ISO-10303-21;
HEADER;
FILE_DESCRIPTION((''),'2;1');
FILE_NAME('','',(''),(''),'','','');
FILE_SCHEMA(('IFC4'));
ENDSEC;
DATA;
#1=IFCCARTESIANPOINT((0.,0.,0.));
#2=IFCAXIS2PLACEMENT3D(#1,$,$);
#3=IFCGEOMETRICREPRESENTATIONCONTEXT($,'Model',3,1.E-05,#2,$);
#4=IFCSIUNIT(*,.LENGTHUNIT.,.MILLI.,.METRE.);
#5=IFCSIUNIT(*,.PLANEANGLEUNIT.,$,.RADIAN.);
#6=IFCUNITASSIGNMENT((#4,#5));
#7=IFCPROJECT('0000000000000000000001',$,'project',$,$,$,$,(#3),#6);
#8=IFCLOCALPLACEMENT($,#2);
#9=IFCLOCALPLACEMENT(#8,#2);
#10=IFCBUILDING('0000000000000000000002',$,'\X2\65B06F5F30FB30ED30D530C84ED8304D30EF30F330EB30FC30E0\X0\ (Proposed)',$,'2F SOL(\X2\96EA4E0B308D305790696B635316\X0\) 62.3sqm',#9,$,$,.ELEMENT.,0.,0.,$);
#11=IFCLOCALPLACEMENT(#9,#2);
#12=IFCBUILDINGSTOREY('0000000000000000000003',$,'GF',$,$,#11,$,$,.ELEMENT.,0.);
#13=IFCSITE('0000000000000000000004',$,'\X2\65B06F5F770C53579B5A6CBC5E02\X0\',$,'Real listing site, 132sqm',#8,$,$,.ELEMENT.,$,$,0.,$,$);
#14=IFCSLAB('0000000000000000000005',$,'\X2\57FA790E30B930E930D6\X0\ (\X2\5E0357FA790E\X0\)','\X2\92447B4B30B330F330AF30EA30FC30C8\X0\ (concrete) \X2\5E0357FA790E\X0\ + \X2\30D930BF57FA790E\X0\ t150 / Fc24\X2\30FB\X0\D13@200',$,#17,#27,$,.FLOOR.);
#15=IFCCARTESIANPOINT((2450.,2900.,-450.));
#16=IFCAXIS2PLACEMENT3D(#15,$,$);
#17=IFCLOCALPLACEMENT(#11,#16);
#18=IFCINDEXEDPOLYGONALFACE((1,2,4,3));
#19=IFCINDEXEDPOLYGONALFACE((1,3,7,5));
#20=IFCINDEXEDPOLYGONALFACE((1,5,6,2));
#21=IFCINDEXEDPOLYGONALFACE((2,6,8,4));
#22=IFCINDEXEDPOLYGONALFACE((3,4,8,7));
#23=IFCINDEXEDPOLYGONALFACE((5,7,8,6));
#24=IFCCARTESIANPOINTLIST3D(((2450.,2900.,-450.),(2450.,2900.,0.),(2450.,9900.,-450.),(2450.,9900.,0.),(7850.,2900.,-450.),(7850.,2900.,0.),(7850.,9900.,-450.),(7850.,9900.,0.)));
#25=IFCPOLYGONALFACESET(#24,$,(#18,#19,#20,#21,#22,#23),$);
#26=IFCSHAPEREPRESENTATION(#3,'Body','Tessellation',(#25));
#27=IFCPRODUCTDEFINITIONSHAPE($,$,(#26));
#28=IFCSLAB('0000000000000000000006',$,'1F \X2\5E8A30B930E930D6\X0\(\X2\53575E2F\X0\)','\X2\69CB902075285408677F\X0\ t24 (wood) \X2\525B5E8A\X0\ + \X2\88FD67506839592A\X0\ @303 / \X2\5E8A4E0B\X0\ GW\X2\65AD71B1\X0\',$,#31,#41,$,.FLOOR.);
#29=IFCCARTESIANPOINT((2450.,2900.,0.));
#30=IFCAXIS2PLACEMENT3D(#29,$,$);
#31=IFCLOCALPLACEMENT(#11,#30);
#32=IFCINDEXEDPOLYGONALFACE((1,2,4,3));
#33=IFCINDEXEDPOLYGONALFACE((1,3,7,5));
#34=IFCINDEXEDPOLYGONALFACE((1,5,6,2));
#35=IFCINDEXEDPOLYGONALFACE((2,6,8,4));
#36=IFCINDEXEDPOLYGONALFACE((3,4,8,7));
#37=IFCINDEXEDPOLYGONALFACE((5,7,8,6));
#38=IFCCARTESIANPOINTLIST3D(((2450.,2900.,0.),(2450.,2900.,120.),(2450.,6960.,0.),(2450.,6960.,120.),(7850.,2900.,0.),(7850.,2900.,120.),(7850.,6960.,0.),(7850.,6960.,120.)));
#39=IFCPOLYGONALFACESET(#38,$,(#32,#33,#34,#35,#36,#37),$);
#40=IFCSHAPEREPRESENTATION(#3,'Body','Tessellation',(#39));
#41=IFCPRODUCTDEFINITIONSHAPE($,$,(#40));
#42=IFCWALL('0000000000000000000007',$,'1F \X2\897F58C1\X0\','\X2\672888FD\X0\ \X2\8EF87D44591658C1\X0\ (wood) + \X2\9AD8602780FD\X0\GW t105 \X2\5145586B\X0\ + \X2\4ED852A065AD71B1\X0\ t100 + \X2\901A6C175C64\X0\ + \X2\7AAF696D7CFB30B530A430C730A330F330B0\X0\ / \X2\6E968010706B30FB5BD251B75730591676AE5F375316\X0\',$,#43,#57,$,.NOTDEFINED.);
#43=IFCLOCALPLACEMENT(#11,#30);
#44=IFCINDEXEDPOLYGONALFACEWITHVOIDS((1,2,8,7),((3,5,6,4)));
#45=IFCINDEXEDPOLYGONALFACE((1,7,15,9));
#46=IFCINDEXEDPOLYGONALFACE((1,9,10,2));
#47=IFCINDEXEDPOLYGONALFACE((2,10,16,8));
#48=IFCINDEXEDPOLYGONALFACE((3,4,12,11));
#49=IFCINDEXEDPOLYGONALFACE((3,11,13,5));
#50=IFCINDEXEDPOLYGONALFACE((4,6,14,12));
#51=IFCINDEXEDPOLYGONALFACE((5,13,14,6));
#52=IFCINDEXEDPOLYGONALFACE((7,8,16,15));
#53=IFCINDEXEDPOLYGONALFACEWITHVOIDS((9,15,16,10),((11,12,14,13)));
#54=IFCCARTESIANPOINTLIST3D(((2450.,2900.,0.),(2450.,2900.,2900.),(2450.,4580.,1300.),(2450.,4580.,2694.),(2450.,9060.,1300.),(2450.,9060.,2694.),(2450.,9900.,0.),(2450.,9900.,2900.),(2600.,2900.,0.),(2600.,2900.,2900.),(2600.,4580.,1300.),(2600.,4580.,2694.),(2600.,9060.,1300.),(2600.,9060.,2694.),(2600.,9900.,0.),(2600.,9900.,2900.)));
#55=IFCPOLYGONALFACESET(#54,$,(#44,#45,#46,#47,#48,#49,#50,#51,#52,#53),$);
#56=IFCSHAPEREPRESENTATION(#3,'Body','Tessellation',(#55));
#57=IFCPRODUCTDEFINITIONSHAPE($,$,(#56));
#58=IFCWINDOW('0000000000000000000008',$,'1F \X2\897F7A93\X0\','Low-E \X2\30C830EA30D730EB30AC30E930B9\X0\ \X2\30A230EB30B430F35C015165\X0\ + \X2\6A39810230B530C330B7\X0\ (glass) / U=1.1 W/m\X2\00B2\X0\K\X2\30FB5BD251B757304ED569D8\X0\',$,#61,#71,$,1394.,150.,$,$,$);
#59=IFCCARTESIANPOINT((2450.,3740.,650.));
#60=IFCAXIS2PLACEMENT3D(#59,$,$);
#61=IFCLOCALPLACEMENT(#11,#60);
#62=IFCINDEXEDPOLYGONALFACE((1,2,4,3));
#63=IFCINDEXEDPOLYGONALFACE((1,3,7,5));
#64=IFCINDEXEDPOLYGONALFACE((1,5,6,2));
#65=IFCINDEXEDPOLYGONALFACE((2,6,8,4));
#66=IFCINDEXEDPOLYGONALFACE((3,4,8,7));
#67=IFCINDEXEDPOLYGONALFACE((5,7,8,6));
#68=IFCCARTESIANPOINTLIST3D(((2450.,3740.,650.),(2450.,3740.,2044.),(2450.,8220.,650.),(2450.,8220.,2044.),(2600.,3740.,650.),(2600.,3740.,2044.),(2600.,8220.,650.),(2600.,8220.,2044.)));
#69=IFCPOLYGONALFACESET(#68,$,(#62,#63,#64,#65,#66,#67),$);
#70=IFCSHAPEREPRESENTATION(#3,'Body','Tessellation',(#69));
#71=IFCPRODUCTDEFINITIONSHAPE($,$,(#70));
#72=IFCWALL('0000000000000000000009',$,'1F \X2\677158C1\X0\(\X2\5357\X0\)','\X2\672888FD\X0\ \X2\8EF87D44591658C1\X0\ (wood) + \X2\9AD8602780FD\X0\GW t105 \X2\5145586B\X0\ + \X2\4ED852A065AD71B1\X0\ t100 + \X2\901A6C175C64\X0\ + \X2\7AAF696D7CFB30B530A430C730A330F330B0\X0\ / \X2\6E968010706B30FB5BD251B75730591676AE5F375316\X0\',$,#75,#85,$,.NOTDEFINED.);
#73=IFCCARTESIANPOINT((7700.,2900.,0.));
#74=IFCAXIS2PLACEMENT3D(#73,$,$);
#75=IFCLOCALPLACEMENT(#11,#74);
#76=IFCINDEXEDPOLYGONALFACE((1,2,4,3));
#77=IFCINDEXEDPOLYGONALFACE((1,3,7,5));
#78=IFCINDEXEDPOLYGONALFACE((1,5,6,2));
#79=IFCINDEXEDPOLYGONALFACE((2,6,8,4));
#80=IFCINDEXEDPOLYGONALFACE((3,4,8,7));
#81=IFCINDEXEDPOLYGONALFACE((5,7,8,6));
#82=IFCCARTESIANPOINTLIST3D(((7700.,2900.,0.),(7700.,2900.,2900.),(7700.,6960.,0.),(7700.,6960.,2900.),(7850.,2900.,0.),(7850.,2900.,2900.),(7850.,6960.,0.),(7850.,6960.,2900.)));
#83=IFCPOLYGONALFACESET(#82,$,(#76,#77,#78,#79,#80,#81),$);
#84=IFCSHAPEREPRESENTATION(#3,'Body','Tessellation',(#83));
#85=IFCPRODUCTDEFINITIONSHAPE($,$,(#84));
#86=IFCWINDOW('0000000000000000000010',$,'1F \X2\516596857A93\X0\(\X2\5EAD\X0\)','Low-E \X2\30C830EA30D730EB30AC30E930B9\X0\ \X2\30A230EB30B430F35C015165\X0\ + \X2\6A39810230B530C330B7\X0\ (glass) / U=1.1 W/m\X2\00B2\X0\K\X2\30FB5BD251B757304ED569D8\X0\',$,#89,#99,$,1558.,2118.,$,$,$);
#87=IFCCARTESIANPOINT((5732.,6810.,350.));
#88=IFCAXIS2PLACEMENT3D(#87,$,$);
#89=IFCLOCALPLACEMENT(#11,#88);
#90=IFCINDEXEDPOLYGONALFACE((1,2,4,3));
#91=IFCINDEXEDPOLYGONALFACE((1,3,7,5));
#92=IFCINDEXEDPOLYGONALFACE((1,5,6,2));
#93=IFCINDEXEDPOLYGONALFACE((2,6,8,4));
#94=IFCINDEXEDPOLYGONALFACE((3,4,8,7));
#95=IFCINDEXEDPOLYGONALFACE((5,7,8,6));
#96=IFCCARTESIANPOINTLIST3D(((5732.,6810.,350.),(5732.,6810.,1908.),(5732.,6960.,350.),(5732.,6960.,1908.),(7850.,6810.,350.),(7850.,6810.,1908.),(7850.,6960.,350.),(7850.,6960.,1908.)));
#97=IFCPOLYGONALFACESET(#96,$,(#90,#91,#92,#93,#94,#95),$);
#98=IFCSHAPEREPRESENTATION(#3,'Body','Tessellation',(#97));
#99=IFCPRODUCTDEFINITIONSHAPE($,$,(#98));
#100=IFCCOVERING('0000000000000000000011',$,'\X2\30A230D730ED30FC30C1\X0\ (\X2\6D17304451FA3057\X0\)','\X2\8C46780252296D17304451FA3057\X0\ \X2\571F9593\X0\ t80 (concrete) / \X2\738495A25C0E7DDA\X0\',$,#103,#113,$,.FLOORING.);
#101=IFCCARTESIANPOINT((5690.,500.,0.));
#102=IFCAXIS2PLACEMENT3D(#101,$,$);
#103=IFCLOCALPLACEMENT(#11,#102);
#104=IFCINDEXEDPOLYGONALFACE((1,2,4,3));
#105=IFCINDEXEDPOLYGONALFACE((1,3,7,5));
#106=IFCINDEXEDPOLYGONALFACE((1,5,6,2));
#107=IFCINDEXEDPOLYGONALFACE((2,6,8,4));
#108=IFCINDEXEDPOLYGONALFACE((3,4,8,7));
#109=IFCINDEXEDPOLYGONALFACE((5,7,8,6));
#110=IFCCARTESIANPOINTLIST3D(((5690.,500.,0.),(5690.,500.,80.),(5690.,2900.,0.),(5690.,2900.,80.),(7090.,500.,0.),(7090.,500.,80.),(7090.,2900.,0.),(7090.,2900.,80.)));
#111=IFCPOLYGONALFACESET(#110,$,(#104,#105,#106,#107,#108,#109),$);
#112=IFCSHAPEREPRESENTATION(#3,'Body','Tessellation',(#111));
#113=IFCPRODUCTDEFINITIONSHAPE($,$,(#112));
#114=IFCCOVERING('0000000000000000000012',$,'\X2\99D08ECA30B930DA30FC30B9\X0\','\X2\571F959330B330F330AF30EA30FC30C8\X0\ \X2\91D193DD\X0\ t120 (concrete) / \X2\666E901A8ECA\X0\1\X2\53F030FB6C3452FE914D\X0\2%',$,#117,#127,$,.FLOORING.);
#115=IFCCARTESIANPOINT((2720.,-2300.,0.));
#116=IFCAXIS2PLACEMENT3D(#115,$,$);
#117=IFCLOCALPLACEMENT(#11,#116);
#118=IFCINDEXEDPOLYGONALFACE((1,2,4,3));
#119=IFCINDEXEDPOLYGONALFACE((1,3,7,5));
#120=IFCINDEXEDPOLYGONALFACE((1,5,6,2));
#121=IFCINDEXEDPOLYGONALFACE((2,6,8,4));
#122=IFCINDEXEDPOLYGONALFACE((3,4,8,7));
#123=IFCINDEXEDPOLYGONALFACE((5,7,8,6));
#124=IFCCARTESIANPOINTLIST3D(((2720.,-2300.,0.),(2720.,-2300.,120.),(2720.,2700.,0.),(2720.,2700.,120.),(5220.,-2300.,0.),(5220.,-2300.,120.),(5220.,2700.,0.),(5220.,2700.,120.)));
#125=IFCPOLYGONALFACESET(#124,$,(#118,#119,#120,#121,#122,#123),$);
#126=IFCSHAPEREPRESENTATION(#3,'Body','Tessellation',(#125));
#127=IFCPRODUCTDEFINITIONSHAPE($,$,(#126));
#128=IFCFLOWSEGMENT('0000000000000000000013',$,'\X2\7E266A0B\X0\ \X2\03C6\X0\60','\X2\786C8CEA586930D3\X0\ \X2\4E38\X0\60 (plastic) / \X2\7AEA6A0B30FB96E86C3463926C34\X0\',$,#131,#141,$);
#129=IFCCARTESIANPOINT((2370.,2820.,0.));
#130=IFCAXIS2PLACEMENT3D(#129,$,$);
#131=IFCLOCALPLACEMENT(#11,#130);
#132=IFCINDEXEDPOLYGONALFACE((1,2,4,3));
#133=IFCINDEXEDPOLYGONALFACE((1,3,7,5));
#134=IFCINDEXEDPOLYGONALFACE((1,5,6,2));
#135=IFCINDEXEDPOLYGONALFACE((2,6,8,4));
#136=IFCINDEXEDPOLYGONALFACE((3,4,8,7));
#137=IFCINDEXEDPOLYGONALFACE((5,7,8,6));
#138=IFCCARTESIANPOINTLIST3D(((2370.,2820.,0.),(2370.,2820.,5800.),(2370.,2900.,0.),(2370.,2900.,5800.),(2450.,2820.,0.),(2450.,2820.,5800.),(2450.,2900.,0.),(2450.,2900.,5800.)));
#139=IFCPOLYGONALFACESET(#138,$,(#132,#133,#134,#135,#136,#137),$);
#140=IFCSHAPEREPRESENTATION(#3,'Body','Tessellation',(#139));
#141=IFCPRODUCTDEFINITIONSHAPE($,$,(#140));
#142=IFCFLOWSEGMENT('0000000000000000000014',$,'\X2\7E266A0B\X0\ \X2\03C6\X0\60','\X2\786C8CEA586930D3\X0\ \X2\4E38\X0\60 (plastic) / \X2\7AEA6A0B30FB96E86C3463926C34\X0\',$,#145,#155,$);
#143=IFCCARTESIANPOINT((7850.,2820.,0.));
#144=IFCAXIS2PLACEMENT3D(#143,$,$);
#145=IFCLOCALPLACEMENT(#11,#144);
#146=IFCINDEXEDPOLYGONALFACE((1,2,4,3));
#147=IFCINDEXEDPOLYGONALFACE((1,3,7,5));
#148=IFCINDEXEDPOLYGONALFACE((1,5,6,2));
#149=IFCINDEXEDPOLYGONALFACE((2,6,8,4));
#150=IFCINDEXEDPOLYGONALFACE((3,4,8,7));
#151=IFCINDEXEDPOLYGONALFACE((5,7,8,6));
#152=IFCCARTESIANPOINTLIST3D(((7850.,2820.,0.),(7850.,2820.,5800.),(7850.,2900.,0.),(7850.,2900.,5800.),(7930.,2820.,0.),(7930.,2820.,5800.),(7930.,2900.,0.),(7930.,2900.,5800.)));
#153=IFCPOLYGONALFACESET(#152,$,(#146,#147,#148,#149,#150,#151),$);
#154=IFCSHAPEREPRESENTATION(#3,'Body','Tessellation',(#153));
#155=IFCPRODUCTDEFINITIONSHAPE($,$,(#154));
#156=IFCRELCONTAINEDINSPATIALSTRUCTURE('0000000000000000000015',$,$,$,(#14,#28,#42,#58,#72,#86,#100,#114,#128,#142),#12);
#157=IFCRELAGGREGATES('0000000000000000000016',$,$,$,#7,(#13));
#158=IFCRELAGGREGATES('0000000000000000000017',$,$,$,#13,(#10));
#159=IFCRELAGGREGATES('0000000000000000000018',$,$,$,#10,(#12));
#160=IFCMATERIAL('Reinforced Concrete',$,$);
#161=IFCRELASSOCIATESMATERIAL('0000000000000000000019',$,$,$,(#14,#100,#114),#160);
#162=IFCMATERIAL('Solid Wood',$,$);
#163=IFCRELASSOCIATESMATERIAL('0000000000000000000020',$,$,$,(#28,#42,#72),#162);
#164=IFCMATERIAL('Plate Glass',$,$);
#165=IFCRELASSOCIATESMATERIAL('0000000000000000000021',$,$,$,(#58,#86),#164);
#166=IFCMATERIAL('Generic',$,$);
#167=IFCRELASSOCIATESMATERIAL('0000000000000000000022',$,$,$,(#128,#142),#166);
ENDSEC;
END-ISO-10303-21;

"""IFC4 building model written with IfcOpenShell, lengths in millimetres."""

from ifc_helpers import new_model, si_unit, frame, frame_2d, origin, place, context, project, spatial, rectangle, extrude, material, element, fill, save


model = new_model("IFC4")

# Units and contexts
model_context = context("Model", 3, precision=1e-05, world=origin())
ifc_project = project(units=[si_unit("LENGTHUNIT", "METRE", prefix="MILLI"), si_unit("PLANEANGLEUNIT", "RADIAN")], contexts=[model_context])

# Site, building, storey
site_placement = place(None, origin())
site = spatial("IfcSite", under=ifc_project, at=site_placement, Name="新潟県南魚沼市", ObjectType="Real listing site, 132sqm", CompositionType="ELEMENT", RefElevation=0.0)
building_placement = place(site_placement, origin())
building = spatial("IfcBuilding", under=site, at=building_placement, Name="新潟・ロフト付きワンルーム (Proposed)", ObjectType="2F SOL(雪下ろし適正化) 62.3sqm", CompositionType="ELEMENT", ElevationOfRefHeight=0.0, ElevationOfTerrain=0.0)
storey_placement = place(building_placement, origin())
storey = spatial("IfcBuildingStorey", under=building, at=storey_placement, Name="GF", CompositionType="ELEMENT", Elevation=0.0)

# Shared definitions
ifc_material_1 = material(Name="Solid Wood")

# Slabs
ifc_material_2 = material(Name="Reinforced Concrete")
slab_1_placement = place(storey_placement, frame((2450.0, 2900.0, -450.0)))
element("IfcSlab", 1, at=slab_1_placement, inside=storey, material=ifc_material_2, Name="基礎スラブ (布基礎)", Description="鉄筋コンクリート (concrete) 布基礎 + ベタ基礎 t150 / Fc24・D13@200", PredefinedType="FLOOR", context=model_context, shape_type="SweptSolid", body=[
    extrude(rectangle(XDim=5400.0, YDim=7000.0, at=frame_2d((2700.0, 3500.0))), frame((2450.0, 2900.0, -450.0)), (0.0, 0.0, 1.0), 450.0),
])
slab_2_placement = place(storey_placement, frame((2450.0, 2900.0, 0.0)))
element("IfcSlab", 2, at=slab_2_placement, inside=storey, material=ifc_material_1, Name="1F 床スラブ(南帯)", Description="構造用合板 t24 (wood) 剛床 + 製材根太 @303 / 床下 GW断熱", PredefinedType="FLOOR", context=model_context, shape_type="SweptSolid", body=[
    extrude(rectangle(XDim=5400.0, YDim=4060.0, at=frame_2d((2700.0, 2030.0))), frame((2450.0, 2900.0, 0.0)), (0.0, 0.0, 1.0), 120.0),
])

# Shared definitions
ifc_material_3 = material(Name="Plate Glass")

# Walls, openings, windows
wall_1_placement = place(storey_placement, frame((2450.0, 2900.0, 0.0)))
wall_1 = element("IfcWall", 3, at=wall_1_placement, inside=storey, material=ifc_material_1, Name="1F 西壁", Description="木製 軸組外壁 (wood) + 高性能GW t105 充填 + 付加断熱 t100 + 通気層 + 窯業系サイディング / 準耐火・寒冷地外皮強化", PredefinedType="NOTDEFINED", context=model_context, shape_type="SweptSolid", body=[
    extrude(rectangle(XDim=150.0, YDim=7000.0, at=frame_2d((75.0, 3500.0))), frame((2450.0, 2900.0, 0.0)), (0.0, 0.0, 1.0), 2900.0),
])
opening_1_placement = place(storey_placement, frame((2450.0, 3740.0, 650.0)))
opening_1 = element("IfcOpeningElement", 4, at=opening_1_placement, cuts=wall_1, PredefinedType="NOTDEFINED", context=model_context, shape_type="SweptSolid", body=[
    extrude(rectangle(XDim=150.0, YDim=4480.0, at=frame_2d((75.0, 2240.0))), frame((2450.0, 3740.0, 650.0)), (0.0, 0.0, 1.0), 1394.0),
])
window_1_placement = place(storey_placement, frame((2450.0, 3740.0, 650.0)))
window_1 = element("IfcWindow", 5, at=window_1_placement, inside=storey, material=ifc_material_3, Name="1F 西窓", Description="Low-E トリプルガラス アルゴン封入 + 樹脂サッシ (glass) / U=1.1 W/m²K・寒冷地仕様", OverallHeight=1394.0, OverallWidth=150.0, context=model_context, shape_type="SweptSolid", body=[
    extrude(rectangle(XDim=150.0, YDim=4480.0, at=frame_2d((75.0, 2240.0))), frame((2450.0, 3740.0, 650.0)), (0.0, 0.0, 1.0), 1394.0),
])
fill(opening_1, window_1)
wall_2_placement = place(storey_placement, frame((7700.0, 2900.0, 0.0)))
wall_2 = element("IfcWall", 6, at=wall_2_placement, inside=storey, material=ifc_material_1, Name="1F 東壁(南)", Description="木製 軸組外壁 (wood) + 高性能GW t105 充填 + 付加断熱 t100 + 通気層 + 窯業系サイディング / 準耐火・寒冷地外皮強化", PredefinedType="NOTDEFINED", context=model_context, shape_type="SweptSolid", body=[
    extrude(rectangle(XDim=150.0, YDim=4060.0, at=frame_2d((75.0, 2030.0))), frame((7700.0, 2900.0, 0.0)), (0.0, 0.0, 1.0), 2900.0),
])
opening_2_placement = place(storey_placement, frame((5732.0, 6810.0, 350.0)))
opening_2 = element("IfcOpeningElement", 7, at=opening_2_placement, cuts=wall_2, PredefinedType="NOTDEFINED", context=model_context, shape_type="SweptSolid", body=[
    extrude(rectangle(XDim=2118.0, YDim=150.0, at=frame_2d((1059.0, 75.0))), frame((5732.0, 6810.0, 350.0)), (0.0, 0.0, 1.0), 1558.0),
])
window_2_placement = place(storey_placement, frame((5732.0, 6810.0, 350.0)))
window_2 = element("IfcWindow", 8, at=window_2_placement, inside=storey, material=ifc_material_3, Name="1F 入隅窓(庭)", Description="Low-E トリプルガラス アルゴン封入 + 樹脂サッシ (glass) / U=1.1 W/m²K・寒冷地仕様", OverallHeight=1558.0, OverallWidth=2118.0, context=model_context, shape_type="SweptSolid", body=[
    extrude(rectangle(XDim=2118.0, YDim=150.0, at=frame_2d((1059.0, 75.0))), frame((5732.0, 6810.0, 350.0)), (0.0, 0.0, 1.0), 1558.0),
])
fill(opening_2, window_2)

# Coverings
covering_1_placement = place(storey_placement, frame((5690.0, 500.0, 0.0)))
element("IfcCovering", 9, at=covering_1_placement, inside=storey, material=ifc_material_2, Name="アプローチ (洗い出し)", Description="豆砂利洗い出し 土間 t80 (concrete) / 玄関導線", PredefinedType="FLOORING", context=model_context, shape_type="SweptSolid", body=[
    extrude(rectangle(XDim=1400.0, YDim=2400.0, at=frame_2d((700.0, 1200.0))), frame((5690.0, 500.0, 0.0)), (0.0, 0.0, 1.0), 80.0),
])
covering_2_placement = place(storey_placement, frame((2720.0, -2300.0, 0.0)))
element("IfcCovering", 10, at=covering_2_placement, inside=storey, material=ifc_material_2, Name="駐車スペース", Description="土間コンクリート 金鏝 t120 (concrete) / 普通車1台・水勾配2%", PredefinedType="FLOORING", context=model_context, shape_type="SweptSolid", body=[
    extrude(rectangle(XDim=2500.0, YDim=5000.0, at=frame_2d((1250.0, 2500.0))), frame((2720.0, -2300.0, 0.0)), (0.0, 0.0, 1.0), 120.0),
])

# Flow segments
ifc_material_4 = material(Name="Generic")
flow_segment_1_placement = place(storey_placement, frame((2370.0, 2820.0, 0.0)))
element("IfcFlowSegment", 11, at=flow_segment_1_placement, inside=storey, material=ifc_material_4, Name="縦樋 φ60", Description="硬質塩ビ 丸60 (plastic) / 竪樋・雨水排水", context=model_context, shape_type="SweptSolid", body=[
    extrude(rectangle(XDim=80.0, YDim=80.0, at=frame_2d((40.0, 40.0))), frame((2370.0, 2820.0, 0.0)), (0.0, 0.0, 1.0), 5800.0),
])
flow_segment_2_placement = place(storey_placement, frame((7850.0, 2820.0, 0.0)))
element("IfcFlowSegment", 12, at=flow_segment_2_placement, inside=storey, material=ifc_material_4, Name="縦樋 φ60", Description="硬質塩ビ 丸60 (plastic) / 竪樋・雨水排水", context=model_context, shape_type="SweptSolid", body=[
    extrude(rectangle(XDim=80.0, YDim=80.0, at=frame_2d((40.0, 40.0))), frame((7850.0, 2820.0, 0.0)), (0.0, 0.0, 1.0), 5800.0),
])

save(model, "model.ifc")
